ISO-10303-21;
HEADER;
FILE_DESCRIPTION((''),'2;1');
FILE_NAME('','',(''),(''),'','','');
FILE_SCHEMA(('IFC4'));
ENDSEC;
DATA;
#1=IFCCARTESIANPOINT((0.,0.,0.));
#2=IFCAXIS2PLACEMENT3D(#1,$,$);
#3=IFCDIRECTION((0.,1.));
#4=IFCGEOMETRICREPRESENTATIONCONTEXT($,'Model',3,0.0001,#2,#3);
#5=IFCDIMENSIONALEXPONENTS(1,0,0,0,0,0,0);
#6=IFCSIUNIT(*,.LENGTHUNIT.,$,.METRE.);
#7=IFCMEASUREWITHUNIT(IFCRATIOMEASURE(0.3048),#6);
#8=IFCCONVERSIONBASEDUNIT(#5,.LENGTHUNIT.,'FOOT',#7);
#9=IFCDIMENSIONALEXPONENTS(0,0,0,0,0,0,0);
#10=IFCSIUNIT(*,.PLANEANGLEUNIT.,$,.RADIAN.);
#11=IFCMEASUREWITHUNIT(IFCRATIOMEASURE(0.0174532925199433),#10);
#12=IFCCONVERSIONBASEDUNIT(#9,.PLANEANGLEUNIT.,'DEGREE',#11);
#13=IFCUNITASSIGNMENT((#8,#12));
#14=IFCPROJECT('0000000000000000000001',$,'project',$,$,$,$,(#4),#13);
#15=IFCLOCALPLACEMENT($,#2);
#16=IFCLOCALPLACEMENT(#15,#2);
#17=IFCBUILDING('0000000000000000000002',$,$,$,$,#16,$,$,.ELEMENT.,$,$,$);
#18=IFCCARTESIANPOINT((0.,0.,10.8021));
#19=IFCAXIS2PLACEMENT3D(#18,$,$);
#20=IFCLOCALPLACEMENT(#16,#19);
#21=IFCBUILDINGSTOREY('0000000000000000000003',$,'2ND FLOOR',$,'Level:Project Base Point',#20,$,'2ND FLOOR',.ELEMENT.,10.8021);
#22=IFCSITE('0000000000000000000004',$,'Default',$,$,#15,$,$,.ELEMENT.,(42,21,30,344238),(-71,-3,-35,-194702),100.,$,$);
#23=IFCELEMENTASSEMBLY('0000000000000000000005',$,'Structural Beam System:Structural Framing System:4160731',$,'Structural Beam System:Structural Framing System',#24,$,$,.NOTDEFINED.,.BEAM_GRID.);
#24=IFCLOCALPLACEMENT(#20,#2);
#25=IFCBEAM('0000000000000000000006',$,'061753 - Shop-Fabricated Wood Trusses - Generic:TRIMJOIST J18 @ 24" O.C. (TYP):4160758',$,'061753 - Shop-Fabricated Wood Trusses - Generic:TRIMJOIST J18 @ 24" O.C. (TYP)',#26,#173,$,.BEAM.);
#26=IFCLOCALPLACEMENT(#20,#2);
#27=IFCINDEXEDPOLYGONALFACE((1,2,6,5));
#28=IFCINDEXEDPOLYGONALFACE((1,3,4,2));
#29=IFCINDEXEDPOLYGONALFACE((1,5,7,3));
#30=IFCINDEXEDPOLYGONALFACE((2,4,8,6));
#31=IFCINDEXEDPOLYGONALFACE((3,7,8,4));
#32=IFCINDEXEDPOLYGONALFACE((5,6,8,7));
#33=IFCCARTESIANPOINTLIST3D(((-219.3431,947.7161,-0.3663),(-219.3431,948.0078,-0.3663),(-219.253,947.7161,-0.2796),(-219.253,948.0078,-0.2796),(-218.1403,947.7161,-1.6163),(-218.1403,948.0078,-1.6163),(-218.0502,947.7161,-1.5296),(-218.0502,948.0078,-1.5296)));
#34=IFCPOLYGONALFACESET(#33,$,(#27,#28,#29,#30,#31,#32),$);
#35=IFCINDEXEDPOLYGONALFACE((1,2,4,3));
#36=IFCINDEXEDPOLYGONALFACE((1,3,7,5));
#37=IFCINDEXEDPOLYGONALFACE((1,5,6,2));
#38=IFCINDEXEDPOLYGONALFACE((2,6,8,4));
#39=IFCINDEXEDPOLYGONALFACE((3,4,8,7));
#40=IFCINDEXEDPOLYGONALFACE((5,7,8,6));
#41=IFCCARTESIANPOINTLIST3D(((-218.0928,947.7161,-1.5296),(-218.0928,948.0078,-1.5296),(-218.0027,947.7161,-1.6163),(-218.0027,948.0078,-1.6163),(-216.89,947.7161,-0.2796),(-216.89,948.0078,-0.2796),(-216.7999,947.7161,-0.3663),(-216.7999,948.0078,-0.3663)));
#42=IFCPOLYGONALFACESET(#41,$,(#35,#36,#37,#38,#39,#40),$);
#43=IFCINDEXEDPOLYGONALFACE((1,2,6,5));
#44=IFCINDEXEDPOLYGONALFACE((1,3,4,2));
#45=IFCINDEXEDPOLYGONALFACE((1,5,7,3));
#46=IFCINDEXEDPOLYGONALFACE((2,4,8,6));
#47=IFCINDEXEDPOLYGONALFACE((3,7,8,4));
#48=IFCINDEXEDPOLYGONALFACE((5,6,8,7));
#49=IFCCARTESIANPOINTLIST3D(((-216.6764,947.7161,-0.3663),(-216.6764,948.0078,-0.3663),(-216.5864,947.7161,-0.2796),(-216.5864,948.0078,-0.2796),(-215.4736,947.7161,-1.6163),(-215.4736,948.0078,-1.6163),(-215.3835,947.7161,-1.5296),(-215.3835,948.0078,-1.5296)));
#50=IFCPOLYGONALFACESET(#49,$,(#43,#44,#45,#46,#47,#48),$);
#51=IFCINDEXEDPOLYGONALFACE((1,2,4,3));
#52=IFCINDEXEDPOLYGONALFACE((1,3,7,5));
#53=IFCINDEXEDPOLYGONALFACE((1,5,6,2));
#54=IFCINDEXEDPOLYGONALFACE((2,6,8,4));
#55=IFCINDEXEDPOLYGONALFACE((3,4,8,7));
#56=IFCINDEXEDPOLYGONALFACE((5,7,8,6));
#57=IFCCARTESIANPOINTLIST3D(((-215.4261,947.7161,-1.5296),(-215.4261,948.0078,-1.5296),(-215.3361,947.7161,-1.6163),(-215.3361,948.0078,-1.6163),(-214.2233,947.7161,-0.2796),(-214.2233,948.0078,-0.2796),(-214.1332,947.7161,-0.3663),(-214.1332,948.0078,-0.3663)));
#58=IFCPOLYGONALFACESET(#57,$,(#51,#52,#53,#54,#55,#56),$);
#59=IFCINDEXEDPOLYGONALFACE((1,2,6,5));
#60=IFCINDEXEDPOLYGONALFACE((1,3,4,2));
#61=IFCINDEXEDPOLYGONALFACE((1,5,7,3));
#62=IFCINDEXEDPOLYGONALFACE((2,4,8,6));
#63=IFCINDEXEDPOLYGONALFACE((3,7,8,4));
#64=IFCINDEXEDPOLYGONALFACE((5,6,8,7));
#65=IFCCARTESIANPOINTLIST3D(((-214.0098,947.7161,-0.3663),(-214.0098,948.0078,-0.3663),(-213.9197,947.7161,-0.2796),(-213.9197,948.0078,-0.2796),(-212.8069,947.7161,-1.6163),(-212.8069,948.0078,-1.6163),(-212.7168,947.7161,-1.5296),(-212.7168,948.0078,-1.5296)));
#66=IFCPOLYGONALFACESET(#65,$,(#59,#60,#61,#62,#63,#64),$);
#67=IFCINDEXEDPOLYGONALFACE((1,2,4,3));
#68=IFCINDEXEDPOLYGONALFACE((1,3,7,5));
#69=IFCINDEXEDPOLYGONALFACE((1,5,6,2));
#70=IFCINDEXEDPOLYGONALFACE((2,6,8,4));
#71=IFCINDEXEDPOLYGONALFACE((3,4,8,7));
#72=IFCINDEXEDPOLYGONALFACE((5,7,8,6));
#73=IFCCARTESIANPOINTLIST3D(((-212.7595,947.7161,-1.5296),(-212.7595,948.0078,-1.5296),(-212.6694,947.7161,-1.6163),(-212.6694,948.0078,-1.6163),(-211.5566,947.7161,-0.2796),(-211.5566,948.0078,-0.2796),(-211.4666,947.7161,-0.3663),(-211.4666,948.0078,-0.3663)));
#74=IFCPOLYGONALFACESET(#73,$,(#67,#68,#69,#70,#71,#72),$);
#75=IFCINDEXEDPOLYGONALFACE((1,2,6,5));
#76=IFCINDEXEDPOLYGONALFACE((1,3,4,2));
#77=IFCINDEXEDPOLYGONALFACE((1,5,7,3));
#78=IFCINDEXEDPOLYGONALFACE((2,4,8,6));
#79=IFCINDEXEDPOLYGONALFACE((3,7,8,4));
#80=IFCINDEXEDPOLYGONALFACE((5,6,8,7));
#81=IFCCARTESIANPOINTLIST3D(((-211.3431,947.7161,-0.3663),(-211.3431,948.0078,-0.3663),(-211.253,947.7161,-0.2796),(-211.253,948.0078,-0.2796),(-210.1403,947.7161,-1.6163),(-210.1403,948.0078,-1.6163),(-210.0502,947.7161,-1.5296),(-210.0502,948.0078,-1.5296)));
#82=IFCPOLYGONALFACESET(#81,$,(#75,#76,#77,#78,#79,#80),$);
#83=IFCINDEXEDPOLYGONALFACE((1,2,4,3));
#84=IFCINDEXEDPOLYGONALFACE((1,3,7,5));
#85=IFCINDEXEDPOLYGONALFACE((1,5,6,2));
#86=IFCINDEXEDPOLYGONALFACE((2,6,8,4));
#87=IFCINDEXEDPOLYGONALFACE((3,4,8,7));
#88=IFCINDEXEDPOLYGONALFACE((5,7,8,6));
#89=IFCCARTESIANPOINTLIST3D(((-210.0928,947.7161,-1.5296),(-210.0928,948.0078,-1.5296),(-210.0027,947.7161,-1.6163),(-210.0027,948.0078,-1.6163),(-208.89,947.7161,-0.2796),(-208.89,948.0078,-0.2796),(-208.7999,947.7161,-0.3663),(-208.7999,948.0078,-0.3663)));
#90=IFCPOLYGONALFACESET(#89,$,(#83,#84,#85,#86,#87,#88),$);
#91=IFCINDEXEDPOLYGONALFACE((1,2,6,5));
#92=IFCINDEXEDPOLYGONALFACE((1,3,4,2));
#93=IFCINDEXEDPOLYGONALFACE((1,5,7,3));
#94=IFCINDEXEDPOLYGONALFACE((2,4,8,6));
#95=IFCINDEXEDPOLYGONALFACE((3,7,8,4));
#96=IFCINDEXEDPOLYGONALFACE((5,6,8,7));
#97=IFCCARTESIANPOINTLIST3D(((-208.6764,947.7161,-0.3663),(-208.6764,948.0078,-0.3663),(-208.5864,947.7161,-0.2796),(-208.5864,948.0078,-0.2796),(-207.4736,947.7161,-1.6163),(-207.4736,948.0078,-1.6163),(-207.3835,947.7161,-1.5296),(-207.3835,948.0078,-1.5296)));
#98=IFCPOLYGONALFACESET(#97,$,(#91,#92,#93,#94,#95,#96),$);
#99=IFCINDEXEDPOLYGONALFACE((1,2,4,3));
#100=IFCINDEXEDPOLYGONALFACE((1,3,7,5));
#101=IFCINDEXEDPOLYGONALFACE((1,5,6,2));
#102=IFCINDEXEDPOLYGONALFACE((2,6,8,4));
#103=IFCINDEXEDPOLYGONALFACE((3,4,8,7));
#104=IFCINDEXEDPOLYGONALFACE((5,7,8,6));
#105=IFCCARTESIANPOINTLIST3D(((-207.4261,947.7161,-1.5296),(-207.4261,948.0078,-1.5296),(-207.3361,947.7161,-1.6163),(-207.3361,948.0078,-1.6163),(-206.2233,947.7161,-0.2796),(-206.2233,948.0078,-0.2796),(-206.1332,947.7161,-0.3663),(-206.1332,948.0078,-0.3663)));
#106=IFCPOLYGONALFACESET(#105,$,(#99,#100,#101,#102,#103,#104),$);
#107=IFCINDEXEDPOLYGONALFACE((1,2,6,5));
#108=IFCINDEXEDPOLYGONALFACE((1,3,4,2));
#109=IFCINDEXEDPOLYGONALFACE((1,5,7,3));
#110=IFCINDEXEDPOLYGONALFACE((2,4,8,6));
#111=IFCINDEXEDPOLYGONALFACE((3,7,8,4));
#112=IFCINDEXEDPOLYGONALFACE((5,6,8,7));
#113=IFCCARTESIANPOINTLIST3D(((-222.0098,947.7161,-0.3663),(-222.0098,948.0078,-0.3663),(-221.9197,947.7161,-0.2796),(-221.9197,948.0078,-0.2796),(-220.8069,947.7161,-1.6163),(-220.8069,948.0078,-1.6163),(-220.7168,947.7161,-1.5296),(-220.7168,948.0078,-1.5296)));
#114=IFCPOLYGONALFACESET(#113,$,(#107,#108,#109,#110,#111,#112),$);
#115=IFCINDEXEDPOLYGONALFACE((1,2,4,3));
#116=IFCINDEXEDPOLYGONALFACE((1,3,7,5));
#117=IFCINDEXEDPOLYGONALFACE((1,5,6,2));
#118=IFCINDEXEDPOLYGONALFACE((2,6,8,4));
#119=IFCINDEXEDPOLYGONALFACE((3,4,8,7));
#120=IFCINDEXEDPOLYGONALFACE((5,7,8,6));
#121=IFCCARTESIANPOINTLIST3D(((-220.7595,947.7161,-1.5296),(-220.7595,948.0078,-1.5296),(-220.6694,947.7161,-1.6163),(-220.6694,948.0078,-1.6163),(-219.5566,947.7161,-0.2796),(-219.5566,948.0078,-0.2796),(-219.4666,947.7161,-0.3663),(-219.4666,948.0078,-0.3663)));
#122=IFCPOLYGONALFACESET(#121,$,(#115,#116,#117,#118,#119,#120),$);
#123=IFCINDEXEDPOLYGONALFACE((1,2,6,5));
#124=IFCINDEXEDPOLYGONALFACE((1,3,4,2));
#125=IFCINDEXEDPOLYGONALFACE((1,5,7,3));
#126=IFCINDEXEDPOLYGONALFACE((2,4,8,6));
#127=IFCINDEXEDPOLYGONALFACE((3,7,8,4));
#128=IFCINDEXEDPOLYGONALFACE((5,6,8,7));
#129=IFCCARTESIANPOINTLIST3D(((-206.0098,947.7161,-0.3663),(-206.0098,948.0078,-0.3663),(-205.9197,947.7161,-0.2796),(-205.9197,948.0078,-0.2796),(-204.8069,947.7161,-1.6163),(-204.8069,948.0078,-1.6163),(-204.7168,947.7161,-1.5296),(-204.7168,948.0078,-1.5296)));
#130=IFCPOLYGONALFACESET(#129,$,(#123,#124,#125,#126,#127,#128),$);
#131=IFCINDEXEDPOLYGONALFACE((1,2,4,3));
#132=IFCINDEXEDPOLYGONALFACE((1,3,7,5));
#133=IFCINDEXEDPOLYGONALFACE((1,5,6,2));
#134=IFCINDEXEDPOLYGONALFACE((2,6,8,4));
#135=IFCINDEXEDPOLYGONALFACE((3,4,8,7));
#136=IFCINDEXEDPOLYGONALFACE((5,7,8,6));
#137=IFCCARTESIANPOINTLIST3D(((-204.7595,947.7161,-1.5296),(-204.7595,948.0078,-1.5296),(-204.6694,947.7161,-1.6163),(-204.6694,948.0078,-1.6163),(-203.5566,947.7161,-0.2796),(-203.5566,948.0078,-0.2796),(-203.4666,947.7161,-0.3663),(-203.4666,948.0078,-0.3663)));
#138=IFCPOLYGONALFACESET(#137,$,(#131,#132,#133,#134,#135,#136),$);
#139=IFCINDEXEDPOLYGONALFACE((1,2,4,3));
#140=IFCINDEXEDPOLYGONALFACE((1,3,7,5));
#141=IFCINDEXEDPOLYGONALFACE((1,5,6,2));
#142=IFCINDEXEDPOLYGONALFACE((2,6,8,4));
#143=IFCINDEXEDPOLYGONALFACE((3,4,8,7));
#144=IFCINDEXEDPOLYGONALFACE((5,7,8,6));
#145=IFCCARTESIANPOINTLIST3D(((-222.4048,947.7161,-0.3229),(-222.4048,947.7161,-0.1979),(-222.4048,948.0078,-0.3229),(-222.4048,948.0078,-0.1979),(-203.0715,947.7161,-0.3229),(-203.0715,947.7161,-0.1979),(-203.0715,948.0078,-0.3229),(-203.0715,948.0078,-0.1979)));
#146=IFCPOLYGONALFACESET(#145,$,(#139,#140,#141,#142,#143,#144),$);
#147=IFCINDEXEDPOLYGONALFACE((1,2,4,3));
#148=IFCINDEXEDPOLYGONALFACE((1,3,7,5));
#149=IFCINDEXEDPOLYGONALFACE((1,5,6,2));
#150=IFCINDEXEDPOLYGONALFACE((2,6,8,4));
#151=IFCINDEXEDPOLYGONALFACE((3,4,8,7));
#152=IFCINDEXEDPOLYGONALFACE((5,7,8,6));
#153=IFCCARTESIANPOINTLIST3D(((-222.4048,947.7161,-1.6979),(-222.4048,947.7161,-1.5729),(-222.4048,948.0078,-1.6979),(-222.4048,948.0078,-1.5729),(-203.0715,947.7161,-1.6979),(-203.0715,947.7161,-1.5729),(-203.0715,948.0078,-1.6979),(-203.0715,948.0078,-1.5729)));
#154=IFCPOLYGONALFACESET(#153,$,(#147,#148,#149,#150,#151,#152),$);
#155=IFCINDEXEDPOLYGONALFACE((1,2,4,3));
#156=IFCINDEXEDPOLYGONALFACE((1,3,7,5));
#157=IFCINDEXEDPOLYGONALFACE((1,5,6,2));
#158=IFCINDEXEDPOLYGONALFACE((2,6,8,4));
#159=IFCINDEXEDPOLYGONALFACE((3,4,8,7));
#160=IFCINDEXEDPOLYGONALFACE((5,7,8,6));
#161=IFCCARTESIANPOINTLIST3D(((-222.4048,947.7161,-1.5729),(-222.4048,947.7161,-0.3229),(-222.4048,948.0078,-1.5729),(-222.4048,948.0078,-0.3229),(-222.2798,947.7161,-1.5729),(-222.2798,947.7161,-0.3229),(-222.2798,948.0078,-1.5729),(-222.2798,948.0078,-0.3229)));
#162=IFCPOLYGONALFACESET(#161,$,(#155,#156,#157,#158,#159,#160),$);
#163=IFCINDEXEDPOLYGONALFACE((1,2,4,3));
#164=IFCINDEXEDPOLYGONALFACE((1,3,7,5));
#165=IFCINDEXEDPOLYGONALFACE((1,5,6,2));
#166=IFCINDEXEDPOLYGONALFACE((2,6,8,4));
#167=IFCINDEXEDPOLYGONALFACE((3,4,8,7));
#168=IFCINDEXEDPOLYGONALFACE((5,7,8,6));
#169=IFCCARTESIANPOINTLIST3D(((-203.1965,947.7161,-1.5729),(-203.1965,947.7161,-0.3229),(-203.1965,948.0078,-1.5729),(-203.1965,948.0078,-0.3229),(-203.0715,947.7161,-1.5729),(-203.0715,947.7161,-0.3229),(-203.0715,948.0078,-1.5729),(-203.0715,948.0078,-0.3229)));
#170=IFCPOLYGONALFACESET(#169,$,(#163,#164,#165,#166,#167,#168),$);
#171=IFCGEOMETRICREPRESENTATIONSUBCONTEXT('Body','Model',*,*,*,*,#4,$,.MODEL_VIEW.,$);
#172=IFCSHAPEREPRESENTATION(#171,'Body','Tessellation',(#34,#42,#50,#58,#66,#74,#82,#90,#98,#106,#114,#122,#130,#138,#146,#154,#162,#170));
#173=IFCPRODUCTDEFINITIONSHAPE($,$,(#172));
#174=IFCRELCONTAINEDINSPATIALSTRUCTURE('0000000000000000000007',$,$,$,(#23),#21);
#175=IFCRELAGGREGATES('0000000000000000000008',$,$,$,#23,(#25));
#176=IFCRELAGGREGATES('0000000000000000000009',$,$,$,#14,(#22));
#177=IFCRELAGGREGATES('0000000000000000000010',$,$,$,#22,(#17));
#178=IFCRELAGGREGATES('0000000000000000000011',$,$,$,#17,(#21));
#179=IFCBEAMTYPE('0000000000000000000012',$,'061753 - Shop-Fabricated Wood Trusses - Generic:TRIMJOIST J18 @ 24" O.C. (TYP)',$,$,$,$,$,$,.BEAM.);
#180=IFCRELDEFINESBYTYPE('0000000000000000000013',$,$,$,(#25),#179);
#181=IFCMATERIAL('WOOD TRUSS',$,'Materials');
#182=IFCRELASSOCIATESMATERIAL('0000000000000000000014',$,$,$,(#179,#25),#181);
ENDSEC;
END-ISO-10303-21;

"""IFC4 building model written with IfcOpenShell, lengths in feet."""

from ifc_helpers import new_model, entity, si_unit, converted_unit, direction, frame, frame_2d, origin, origin_2d_with_axis, place, context, subcontext, project, spatial, rectangle, extrude, source, transform, mapped, material, material_profile, profile_set, profile_usage, type_object, type_shapes, element, aggregate, save


model = new_model("IFC4")

# Units and contexts
model_context = context("Model", 3, precision=0.0001, world=origin(), true_north=direction((0.0, 1.0)))
body_context = subcontext(model_context, "Body", "Model", "MODEL_VIEW")
ifc_project = project(units=[converted_unit("LENGTHUNIT", "FOOT", entity("IfcRatioMeasure", 0.3048), si_unit("LENGTHUNIT", "METRE"), dimensions=[1, 0, 0, 0, 0, 0, 0]), converted_unit("PLANEANGLEUNIT", "DEGREE", entity("IfcRatioMeasure", 0.0174532925199433), si_unit("PLANEANGLEUNIT", "RADIAN"), dimensions=[0, 0, 0, 0, 0, 0, 0])], contexts=[model_context])

# Site, building, storey
site_placement = place(None, origin())
site = spatial("IfcSite", under=ifc_project, at=site_placement, Name="Default", CompositionType="ELEMENT", RefLatitude=(42, 21, 30, 344238), RefLongitude=(-71, -3, -35, -194702), RefElevation=100.0)
building_placement = place(site_placement, origin())
building = spatial("IfcBuilding", under=site, at=building_placement, CompositionType="ELEMENT")
storey_placement = place(building_placement, frame((0.0, 0.0, 10.8021)))
storey = spatial("IfcBuildingStorey", under=building, at=storey_placement, Name="2ND FLOOR", ObjectType="Level:Project Base Point", LongName="2ND FLOOR", CompositionType="ELEMENT", Elevation=10.8021)

# Element assembly, beam
ifc_material_1 = material(Name="WOOD TRUSS", Category="Materials")
ifc_material_profile_1 = material_profile(ifc_material_1, rectangle(XDim=1.7347, YDim=0.125, at=frame_2d((0.0, 0.0), x_axis=(1.0, 0.0))), Name="TRIMJOIST J18 @ 24\" O.C. (TYP)")
ifc_material_profile_2 = material_profile(ifc_material_1, rectangle(XDim=1.7347, YDim=0.125, at=frame_2d((0.0, 0.0), x_axis=(1.0, 0.0))), Name="TRIMJOIST J18 @ 24\" O.C. (TYP)")
ifc_material_profile_3 = material_profile(ifc_material_1, rectangle(XDim=1.7347, YDim=0.125, at=frame_2d((0.0, 0.0), x_axis=(1.0, 0.0))), Name="TRIMJOIST J18 @ 24\" O.C. (TYP)")
ifc_material_profile_4 = material_profile(ifc_material_1, rectangle(XDim=1.7347, YDim=0.125, at=frame_2d((0.0, 0.0), x_axis=(1.0, 0.0))), Name="TRIMJOIST J18 @ 24\" O.C. (TYP)")
ifc_material_profile_5 = material_profile(ifc_material_1, rectangle(XDim=1.7347, YDim=0.125, at=frame_2d((0.0, 0.0), x_axis=(1.0, 0.0))), Name="TRIMJOIST J18 @ 24\" O.C. (TYP)")
ifc_material_profile_6 = material_profile(ifc_material_1, rectangle(XDim=1.7347, YDim=0.125, at=frame_2d((0.0, 0.0), x_axis=(1.0, 0.0))), Name="TRIMJOIST J18 @ 24\" O.C. (TYP)")
ifc_material_profile_7 = material_profile(ifc_material_1, rectangle(XDim=1.7347, YDim=0.125, at=frame_2d((0.0, 0.0), x_axis=(1.0, 0.0))), Name="TRIMJOIST J18 @ 24\" O.C. (TYP)")
ifc_material_profile_8 = material_profile(ifc_material_1, rectangle(XDim=1.7347, YDim=0.125, at=frame_2d((0.0, 0.0), x_axis=(1.0, 0.0))), Name="TRIMJOIST J18 @ 24\" O.C. (TYP)")
ifc_material_profile_9 = material_profile(ifc_material_1, rectangle(XDim=1.7347, YDim=0.125, at=frame_2d((0.0, 0.0), x_axis=(1.0, 0.0))), Name="TRIMJOIST J18 @ 24\" O.C. (TYP)")
ifc_material_profile_10 = material_profile(ifc_material_1, rectangle(XDim=1.7347, YDim=0.125, at=origin_2d_with_axis()), Name="TRIMJOIST J18 @ 24\" O.C. (TYP)")
ifc_material_profile_11 = material_profile(ifc_material_1, rectangle(XDim=0.125, YDim=0.2917, at=origin_2d_with_axis()), Name="TRIMJOIST J18 @ 24\" O.C. (TYP)")
ifc_material_profile_12 = material_profile(ifc_material_1, rectangle(XDim=0.125, YDim=0.2917, at=origin_2d_with_axis()), Name="TRIMJOIST J18 @ 24\" O.C. (TYP)")
ifc_material_profile_13 = material_profile(ifc_material_1, rectangle(XDim=1.25, YDim=0.2917, at=origin_2d_with_axis()), Name="TRIMJOIST J18 @ 24\" O.C. (TYP)")
ifc_material_profile_14 = material_profile(ifc_material_1, rectangle(XDim=1.25, YDim=0.2917, at=origin_2d_with_axis()), Name="TRIMJOIST J18 @ 24\" O.C. (TYP)")
ifc_profile_set_1 = profile_set([ifc_material_profile_1, ifc_material_profile_2, ifc_material_profile_3, ifc_material_profile_4, ifc_material_profile_5, ifc_material_profile_6, ifc_material_profile_7, ifc_material_profile_8, ifc_material_profile_9, ifc_material_profile_10, ifc_material_profile_11, ifc_material_profile_12, ifc_material_profile_13, ifc_material_profile_14], Name="TRIMJOIST J18 @ 24\" O.C. (TYP)")
beam_type_1 = type_object("IfcBeamType", Name="061753 - Shop-Fabricated Wood Trusses - Generic:TRIMJOIST J18 @ 24\" O.C. (TYP)", PredefinedType="BEAM", material=ifc_profile_set_1)
shared_shape_1 = source(origin(), body_context, "Body", "SweptSolid", [
    extrude(rectangle(XDim=1.7347, YDim=0.125, at=frame_2d((0.0, 0.0), x_axis=(1.0, 0.0))), frame((5.9585, -0.1458, 0.0), z_axis=(0.0, 1.0, 0.0), x_axis=(0.693383, 0.0, 0.720569)), (0.0, 0.0, 1.0), 0.2917),
    extrude(rectangle(XDim=1.7347, YDim=0.125, at=origin_2d_with_axis()), frame((4.7082, -0.1458, 0.0), z_axis=(0.0, 1.0, 0.0), x_axis=(0.693383, 0.0, -0.720569)), (0.0, 0.0, 1.0), 0.2917),
    extrude(rectangle(XDim=1.7347, YDim=0.125, at=frame_2d((0.0, 0.0), x_axis=(1.0, 0.0))), frame((3.2918, -0.1458, 0.0), z_axis=(0.0, 1.0, 0.0), x_axis=(0.693383, 0.0, 0.720569)), (0.0, 0.0, 1.0), 0.2917),
    extrude(rectangle(XDim=1.7347, YDim=0.125, at=frame_2d((0.0, 0.0), x_axis=(1.0, 0.0))), frame((2.0415, -0.1458, 0.0), z_axis=(0.0, 1.0, 0.0), x_axis=(0.693383, 0.0, -0.720569)), (0.0, 0.0, 1.0), 0.2917),
    extrude(rectangle(XDim=1.7347, YDim=0.125, at=frame_2d((0.0, 0.0), x_axis=(1.0, 0.0))), frame((0.6251, -0.1458, 0.0), z_axis=(0.0, 1.0, 0.0), x_axis=(0.693383, 0.0, 0.720569)), (0.0, 0.0, 1.0), 0.2917),
    extrude(rectangle(XDim=1.7347, YDim=0.125, at=frame_2d((0.0, 0.0), x_axis=(1.0, 0.0))), frame((-0.6251, -0.1458, 0.0), z_axis=(0.0, 1.0, 0.0), x_axis=(0.693383, 0.0, -0.720569)), (0.0, 0.0, 1.0), 0.2917),
    extrude(rectangle(XDim=1.7347, YDim=0.125, at=frame_2d((0.0, 0.0), x_axis=(1.0, 0.0))), frame((-2.0415, -0.1458, 0.0), z_axis=(0.0, 1.0, 0.0), x_axis=(0.693383, 0.0, 0.720569)), (0.0, 0.0, 1.0), 0.2917),
    extrude(rectangle(XDim=1.7347, YDim=0.125, at=origin_2d_with_axis()), frame((-3.2918, -0.1458, 0.0), z_axis=(0.0, 1.0, 0.0), x_axis=(0.693383, 0.0, -0.720569)), (0.0, 0.0, 1.0), 0.2917),
    extrude(rectangle(XDim=1.7347, YDim=0.125, at=frame_2d((0.0, 0.0), x_axis=(1.0, 0.0))), frame((-4.7082, -0.1458, 0.0), z_axis=(0.0, 1.0, 0.0), x_axis=(0.693383, 0.0, 0.720569)), (0.0, 0.0, 1.0), 0.2917),
    extrude(rectangle(XDim=1.7347, YDim=0.125, at=frame_2d((0.0, 0.0), x_axis=(1.0, 0.0))), frame((-5.9585, -0.1458, 0.0), z_axis=(0.0, 1.0, 0.0), x_axis=(0.693383, 0.0, -0.720569)), (0.0, 0.0, 1.0), 0.2917),
    extrude(rectangle(XDim=1.7347, YDim=0.125, at=frame_2d((0.0, 0.0), x_axis=(1.0, 0.0))), frame((8.6251, -0.1458, 0.0), z_axis=(0.0, 1.0, 0.0), x_axis=(0.693383, 0.0, 0.720569)), (0.0, 0.0, 1.0), 0.2917),
    extrude(rectangle(XDim=1.7347, YDim=0.125, at=origin_2d_with_axis()), frame((7.3749, -0.1458, 0.0), z_axis=(0.0, 1.0, 0.0), x_axis=(0.693383, 0.0, -0.720569)), (0.0, 0.0, 1.0), 0.2917),
    extrude(rectangle(XDim=1.7347, YDim=0.125, at=frame_2d((0.0, 0.0), x_axis=(1.0, 0.0))), frame((-7.3749, -0.1458, 0.0), z_axis=(0.0, 1.0, 0.0), x_axis=(0.693383, 0.0, 0.720569)), (0.0, 0.0, 1.0), 0.2917),
    extrude(rectangle(XDim=1.7347, YDim=0.125, at=origin_2d_with_axis()), frame((-8.6251, -0.1458, 0.0), z_axis=(0.0, 1.0, 0.0), x_axis=(0.693383, 0.0, -0.720569)), (0.0, 0.0, 1.0), 0.2917),
    extrude(rectangle(XDim=0.125, YDim=0.2917, at=origin_2d_with_axis()), frame((-9.6667, 0.0, 0.6875), z_axis=(1.0, 0.0, 0.0), x_axis=(0.0, 0.0, -1.0)), (0.0, 0.0, 1.0), 19.3333),
    extrude(rectangle(XDim=0.125, YDim=0.2917, at=origin_2d_with_axis()), frame((-9.6667, 0.0, -0.6875), z_axis=(1.0, 0.0, 0.0), x_axis=(0.0, 0.0, -1.0)), (0.0, 0.0, 1.0), 19.3333),
    extrude(rectangle(XDim=1.25, YDim=0.2917, at=origin_2d_with_axis()), frame((9.5417, 0.0, 0.0), z_axis=(1.0, 0.0, 0.0), x_axis=(0.0, 0.0, -1.0)), (0.0, 0.0, 1.0), 0.125),
    extrude(rectangle(XDim=1.25, YDim=0.2917, at=origin_2d_with_axis()), frame((-9.6667, 0.0, 0.0), z_axis=(1.0, 0.0, 0.0), x_axis=(0.0, 0.0, -1.0)), (0.0, 0.0, 1.0), 0.125),
])
type_shapes(beam_type_1, [shared_shape_1])
assembly_1_placement = place(storey_placement, origin())
assembly_1 = element("IfcElementAssembly", 1, at=assembly_1_placement, inside=storey, Name="Structural Beam System:Structural Framing System:4160731", ObjectType="Structural Beam System:Structural Framing System", AssemblyPlace="NOTDEFINED", PredefinedType="BEAM_GRID")
ifc_profile_usage_1 = profile_usage(ifc_profile_set_1, cardinal=8)
beam_1_placement = place(assembly_1_placement, frame((-212.7382, 947.8619, -0.9479), z_axis=(0.0, 0.0, 1.0), x_axis=(-1.0, 0.0, 0.0)))
beam_1 = element("IfcBeam", 2, at=beam_1_placement, type_object=beam_type_1, material=ifc_profile_usage_1, Name="061753 - Shop-Fabricated Wood Trusses - Generic:TRIMJOIST J18 @ 24\" O.C. (TYP):4160758", ObjectType="061753 - Shop-Fabricated Wood Trusses - Generic:TRIMJOIST J18 @ 24\" O.C. (TYP)", PredefinedType="BEAM", context=body_context, shape_type="MappedRepresentation", body=[
    mapped(shared_shape_1, transform((0.0, 0.0, 0.0), scale=1.0)),
])
aggregate(assembly_1, [beam_1])

save(model, "model.ifc")
